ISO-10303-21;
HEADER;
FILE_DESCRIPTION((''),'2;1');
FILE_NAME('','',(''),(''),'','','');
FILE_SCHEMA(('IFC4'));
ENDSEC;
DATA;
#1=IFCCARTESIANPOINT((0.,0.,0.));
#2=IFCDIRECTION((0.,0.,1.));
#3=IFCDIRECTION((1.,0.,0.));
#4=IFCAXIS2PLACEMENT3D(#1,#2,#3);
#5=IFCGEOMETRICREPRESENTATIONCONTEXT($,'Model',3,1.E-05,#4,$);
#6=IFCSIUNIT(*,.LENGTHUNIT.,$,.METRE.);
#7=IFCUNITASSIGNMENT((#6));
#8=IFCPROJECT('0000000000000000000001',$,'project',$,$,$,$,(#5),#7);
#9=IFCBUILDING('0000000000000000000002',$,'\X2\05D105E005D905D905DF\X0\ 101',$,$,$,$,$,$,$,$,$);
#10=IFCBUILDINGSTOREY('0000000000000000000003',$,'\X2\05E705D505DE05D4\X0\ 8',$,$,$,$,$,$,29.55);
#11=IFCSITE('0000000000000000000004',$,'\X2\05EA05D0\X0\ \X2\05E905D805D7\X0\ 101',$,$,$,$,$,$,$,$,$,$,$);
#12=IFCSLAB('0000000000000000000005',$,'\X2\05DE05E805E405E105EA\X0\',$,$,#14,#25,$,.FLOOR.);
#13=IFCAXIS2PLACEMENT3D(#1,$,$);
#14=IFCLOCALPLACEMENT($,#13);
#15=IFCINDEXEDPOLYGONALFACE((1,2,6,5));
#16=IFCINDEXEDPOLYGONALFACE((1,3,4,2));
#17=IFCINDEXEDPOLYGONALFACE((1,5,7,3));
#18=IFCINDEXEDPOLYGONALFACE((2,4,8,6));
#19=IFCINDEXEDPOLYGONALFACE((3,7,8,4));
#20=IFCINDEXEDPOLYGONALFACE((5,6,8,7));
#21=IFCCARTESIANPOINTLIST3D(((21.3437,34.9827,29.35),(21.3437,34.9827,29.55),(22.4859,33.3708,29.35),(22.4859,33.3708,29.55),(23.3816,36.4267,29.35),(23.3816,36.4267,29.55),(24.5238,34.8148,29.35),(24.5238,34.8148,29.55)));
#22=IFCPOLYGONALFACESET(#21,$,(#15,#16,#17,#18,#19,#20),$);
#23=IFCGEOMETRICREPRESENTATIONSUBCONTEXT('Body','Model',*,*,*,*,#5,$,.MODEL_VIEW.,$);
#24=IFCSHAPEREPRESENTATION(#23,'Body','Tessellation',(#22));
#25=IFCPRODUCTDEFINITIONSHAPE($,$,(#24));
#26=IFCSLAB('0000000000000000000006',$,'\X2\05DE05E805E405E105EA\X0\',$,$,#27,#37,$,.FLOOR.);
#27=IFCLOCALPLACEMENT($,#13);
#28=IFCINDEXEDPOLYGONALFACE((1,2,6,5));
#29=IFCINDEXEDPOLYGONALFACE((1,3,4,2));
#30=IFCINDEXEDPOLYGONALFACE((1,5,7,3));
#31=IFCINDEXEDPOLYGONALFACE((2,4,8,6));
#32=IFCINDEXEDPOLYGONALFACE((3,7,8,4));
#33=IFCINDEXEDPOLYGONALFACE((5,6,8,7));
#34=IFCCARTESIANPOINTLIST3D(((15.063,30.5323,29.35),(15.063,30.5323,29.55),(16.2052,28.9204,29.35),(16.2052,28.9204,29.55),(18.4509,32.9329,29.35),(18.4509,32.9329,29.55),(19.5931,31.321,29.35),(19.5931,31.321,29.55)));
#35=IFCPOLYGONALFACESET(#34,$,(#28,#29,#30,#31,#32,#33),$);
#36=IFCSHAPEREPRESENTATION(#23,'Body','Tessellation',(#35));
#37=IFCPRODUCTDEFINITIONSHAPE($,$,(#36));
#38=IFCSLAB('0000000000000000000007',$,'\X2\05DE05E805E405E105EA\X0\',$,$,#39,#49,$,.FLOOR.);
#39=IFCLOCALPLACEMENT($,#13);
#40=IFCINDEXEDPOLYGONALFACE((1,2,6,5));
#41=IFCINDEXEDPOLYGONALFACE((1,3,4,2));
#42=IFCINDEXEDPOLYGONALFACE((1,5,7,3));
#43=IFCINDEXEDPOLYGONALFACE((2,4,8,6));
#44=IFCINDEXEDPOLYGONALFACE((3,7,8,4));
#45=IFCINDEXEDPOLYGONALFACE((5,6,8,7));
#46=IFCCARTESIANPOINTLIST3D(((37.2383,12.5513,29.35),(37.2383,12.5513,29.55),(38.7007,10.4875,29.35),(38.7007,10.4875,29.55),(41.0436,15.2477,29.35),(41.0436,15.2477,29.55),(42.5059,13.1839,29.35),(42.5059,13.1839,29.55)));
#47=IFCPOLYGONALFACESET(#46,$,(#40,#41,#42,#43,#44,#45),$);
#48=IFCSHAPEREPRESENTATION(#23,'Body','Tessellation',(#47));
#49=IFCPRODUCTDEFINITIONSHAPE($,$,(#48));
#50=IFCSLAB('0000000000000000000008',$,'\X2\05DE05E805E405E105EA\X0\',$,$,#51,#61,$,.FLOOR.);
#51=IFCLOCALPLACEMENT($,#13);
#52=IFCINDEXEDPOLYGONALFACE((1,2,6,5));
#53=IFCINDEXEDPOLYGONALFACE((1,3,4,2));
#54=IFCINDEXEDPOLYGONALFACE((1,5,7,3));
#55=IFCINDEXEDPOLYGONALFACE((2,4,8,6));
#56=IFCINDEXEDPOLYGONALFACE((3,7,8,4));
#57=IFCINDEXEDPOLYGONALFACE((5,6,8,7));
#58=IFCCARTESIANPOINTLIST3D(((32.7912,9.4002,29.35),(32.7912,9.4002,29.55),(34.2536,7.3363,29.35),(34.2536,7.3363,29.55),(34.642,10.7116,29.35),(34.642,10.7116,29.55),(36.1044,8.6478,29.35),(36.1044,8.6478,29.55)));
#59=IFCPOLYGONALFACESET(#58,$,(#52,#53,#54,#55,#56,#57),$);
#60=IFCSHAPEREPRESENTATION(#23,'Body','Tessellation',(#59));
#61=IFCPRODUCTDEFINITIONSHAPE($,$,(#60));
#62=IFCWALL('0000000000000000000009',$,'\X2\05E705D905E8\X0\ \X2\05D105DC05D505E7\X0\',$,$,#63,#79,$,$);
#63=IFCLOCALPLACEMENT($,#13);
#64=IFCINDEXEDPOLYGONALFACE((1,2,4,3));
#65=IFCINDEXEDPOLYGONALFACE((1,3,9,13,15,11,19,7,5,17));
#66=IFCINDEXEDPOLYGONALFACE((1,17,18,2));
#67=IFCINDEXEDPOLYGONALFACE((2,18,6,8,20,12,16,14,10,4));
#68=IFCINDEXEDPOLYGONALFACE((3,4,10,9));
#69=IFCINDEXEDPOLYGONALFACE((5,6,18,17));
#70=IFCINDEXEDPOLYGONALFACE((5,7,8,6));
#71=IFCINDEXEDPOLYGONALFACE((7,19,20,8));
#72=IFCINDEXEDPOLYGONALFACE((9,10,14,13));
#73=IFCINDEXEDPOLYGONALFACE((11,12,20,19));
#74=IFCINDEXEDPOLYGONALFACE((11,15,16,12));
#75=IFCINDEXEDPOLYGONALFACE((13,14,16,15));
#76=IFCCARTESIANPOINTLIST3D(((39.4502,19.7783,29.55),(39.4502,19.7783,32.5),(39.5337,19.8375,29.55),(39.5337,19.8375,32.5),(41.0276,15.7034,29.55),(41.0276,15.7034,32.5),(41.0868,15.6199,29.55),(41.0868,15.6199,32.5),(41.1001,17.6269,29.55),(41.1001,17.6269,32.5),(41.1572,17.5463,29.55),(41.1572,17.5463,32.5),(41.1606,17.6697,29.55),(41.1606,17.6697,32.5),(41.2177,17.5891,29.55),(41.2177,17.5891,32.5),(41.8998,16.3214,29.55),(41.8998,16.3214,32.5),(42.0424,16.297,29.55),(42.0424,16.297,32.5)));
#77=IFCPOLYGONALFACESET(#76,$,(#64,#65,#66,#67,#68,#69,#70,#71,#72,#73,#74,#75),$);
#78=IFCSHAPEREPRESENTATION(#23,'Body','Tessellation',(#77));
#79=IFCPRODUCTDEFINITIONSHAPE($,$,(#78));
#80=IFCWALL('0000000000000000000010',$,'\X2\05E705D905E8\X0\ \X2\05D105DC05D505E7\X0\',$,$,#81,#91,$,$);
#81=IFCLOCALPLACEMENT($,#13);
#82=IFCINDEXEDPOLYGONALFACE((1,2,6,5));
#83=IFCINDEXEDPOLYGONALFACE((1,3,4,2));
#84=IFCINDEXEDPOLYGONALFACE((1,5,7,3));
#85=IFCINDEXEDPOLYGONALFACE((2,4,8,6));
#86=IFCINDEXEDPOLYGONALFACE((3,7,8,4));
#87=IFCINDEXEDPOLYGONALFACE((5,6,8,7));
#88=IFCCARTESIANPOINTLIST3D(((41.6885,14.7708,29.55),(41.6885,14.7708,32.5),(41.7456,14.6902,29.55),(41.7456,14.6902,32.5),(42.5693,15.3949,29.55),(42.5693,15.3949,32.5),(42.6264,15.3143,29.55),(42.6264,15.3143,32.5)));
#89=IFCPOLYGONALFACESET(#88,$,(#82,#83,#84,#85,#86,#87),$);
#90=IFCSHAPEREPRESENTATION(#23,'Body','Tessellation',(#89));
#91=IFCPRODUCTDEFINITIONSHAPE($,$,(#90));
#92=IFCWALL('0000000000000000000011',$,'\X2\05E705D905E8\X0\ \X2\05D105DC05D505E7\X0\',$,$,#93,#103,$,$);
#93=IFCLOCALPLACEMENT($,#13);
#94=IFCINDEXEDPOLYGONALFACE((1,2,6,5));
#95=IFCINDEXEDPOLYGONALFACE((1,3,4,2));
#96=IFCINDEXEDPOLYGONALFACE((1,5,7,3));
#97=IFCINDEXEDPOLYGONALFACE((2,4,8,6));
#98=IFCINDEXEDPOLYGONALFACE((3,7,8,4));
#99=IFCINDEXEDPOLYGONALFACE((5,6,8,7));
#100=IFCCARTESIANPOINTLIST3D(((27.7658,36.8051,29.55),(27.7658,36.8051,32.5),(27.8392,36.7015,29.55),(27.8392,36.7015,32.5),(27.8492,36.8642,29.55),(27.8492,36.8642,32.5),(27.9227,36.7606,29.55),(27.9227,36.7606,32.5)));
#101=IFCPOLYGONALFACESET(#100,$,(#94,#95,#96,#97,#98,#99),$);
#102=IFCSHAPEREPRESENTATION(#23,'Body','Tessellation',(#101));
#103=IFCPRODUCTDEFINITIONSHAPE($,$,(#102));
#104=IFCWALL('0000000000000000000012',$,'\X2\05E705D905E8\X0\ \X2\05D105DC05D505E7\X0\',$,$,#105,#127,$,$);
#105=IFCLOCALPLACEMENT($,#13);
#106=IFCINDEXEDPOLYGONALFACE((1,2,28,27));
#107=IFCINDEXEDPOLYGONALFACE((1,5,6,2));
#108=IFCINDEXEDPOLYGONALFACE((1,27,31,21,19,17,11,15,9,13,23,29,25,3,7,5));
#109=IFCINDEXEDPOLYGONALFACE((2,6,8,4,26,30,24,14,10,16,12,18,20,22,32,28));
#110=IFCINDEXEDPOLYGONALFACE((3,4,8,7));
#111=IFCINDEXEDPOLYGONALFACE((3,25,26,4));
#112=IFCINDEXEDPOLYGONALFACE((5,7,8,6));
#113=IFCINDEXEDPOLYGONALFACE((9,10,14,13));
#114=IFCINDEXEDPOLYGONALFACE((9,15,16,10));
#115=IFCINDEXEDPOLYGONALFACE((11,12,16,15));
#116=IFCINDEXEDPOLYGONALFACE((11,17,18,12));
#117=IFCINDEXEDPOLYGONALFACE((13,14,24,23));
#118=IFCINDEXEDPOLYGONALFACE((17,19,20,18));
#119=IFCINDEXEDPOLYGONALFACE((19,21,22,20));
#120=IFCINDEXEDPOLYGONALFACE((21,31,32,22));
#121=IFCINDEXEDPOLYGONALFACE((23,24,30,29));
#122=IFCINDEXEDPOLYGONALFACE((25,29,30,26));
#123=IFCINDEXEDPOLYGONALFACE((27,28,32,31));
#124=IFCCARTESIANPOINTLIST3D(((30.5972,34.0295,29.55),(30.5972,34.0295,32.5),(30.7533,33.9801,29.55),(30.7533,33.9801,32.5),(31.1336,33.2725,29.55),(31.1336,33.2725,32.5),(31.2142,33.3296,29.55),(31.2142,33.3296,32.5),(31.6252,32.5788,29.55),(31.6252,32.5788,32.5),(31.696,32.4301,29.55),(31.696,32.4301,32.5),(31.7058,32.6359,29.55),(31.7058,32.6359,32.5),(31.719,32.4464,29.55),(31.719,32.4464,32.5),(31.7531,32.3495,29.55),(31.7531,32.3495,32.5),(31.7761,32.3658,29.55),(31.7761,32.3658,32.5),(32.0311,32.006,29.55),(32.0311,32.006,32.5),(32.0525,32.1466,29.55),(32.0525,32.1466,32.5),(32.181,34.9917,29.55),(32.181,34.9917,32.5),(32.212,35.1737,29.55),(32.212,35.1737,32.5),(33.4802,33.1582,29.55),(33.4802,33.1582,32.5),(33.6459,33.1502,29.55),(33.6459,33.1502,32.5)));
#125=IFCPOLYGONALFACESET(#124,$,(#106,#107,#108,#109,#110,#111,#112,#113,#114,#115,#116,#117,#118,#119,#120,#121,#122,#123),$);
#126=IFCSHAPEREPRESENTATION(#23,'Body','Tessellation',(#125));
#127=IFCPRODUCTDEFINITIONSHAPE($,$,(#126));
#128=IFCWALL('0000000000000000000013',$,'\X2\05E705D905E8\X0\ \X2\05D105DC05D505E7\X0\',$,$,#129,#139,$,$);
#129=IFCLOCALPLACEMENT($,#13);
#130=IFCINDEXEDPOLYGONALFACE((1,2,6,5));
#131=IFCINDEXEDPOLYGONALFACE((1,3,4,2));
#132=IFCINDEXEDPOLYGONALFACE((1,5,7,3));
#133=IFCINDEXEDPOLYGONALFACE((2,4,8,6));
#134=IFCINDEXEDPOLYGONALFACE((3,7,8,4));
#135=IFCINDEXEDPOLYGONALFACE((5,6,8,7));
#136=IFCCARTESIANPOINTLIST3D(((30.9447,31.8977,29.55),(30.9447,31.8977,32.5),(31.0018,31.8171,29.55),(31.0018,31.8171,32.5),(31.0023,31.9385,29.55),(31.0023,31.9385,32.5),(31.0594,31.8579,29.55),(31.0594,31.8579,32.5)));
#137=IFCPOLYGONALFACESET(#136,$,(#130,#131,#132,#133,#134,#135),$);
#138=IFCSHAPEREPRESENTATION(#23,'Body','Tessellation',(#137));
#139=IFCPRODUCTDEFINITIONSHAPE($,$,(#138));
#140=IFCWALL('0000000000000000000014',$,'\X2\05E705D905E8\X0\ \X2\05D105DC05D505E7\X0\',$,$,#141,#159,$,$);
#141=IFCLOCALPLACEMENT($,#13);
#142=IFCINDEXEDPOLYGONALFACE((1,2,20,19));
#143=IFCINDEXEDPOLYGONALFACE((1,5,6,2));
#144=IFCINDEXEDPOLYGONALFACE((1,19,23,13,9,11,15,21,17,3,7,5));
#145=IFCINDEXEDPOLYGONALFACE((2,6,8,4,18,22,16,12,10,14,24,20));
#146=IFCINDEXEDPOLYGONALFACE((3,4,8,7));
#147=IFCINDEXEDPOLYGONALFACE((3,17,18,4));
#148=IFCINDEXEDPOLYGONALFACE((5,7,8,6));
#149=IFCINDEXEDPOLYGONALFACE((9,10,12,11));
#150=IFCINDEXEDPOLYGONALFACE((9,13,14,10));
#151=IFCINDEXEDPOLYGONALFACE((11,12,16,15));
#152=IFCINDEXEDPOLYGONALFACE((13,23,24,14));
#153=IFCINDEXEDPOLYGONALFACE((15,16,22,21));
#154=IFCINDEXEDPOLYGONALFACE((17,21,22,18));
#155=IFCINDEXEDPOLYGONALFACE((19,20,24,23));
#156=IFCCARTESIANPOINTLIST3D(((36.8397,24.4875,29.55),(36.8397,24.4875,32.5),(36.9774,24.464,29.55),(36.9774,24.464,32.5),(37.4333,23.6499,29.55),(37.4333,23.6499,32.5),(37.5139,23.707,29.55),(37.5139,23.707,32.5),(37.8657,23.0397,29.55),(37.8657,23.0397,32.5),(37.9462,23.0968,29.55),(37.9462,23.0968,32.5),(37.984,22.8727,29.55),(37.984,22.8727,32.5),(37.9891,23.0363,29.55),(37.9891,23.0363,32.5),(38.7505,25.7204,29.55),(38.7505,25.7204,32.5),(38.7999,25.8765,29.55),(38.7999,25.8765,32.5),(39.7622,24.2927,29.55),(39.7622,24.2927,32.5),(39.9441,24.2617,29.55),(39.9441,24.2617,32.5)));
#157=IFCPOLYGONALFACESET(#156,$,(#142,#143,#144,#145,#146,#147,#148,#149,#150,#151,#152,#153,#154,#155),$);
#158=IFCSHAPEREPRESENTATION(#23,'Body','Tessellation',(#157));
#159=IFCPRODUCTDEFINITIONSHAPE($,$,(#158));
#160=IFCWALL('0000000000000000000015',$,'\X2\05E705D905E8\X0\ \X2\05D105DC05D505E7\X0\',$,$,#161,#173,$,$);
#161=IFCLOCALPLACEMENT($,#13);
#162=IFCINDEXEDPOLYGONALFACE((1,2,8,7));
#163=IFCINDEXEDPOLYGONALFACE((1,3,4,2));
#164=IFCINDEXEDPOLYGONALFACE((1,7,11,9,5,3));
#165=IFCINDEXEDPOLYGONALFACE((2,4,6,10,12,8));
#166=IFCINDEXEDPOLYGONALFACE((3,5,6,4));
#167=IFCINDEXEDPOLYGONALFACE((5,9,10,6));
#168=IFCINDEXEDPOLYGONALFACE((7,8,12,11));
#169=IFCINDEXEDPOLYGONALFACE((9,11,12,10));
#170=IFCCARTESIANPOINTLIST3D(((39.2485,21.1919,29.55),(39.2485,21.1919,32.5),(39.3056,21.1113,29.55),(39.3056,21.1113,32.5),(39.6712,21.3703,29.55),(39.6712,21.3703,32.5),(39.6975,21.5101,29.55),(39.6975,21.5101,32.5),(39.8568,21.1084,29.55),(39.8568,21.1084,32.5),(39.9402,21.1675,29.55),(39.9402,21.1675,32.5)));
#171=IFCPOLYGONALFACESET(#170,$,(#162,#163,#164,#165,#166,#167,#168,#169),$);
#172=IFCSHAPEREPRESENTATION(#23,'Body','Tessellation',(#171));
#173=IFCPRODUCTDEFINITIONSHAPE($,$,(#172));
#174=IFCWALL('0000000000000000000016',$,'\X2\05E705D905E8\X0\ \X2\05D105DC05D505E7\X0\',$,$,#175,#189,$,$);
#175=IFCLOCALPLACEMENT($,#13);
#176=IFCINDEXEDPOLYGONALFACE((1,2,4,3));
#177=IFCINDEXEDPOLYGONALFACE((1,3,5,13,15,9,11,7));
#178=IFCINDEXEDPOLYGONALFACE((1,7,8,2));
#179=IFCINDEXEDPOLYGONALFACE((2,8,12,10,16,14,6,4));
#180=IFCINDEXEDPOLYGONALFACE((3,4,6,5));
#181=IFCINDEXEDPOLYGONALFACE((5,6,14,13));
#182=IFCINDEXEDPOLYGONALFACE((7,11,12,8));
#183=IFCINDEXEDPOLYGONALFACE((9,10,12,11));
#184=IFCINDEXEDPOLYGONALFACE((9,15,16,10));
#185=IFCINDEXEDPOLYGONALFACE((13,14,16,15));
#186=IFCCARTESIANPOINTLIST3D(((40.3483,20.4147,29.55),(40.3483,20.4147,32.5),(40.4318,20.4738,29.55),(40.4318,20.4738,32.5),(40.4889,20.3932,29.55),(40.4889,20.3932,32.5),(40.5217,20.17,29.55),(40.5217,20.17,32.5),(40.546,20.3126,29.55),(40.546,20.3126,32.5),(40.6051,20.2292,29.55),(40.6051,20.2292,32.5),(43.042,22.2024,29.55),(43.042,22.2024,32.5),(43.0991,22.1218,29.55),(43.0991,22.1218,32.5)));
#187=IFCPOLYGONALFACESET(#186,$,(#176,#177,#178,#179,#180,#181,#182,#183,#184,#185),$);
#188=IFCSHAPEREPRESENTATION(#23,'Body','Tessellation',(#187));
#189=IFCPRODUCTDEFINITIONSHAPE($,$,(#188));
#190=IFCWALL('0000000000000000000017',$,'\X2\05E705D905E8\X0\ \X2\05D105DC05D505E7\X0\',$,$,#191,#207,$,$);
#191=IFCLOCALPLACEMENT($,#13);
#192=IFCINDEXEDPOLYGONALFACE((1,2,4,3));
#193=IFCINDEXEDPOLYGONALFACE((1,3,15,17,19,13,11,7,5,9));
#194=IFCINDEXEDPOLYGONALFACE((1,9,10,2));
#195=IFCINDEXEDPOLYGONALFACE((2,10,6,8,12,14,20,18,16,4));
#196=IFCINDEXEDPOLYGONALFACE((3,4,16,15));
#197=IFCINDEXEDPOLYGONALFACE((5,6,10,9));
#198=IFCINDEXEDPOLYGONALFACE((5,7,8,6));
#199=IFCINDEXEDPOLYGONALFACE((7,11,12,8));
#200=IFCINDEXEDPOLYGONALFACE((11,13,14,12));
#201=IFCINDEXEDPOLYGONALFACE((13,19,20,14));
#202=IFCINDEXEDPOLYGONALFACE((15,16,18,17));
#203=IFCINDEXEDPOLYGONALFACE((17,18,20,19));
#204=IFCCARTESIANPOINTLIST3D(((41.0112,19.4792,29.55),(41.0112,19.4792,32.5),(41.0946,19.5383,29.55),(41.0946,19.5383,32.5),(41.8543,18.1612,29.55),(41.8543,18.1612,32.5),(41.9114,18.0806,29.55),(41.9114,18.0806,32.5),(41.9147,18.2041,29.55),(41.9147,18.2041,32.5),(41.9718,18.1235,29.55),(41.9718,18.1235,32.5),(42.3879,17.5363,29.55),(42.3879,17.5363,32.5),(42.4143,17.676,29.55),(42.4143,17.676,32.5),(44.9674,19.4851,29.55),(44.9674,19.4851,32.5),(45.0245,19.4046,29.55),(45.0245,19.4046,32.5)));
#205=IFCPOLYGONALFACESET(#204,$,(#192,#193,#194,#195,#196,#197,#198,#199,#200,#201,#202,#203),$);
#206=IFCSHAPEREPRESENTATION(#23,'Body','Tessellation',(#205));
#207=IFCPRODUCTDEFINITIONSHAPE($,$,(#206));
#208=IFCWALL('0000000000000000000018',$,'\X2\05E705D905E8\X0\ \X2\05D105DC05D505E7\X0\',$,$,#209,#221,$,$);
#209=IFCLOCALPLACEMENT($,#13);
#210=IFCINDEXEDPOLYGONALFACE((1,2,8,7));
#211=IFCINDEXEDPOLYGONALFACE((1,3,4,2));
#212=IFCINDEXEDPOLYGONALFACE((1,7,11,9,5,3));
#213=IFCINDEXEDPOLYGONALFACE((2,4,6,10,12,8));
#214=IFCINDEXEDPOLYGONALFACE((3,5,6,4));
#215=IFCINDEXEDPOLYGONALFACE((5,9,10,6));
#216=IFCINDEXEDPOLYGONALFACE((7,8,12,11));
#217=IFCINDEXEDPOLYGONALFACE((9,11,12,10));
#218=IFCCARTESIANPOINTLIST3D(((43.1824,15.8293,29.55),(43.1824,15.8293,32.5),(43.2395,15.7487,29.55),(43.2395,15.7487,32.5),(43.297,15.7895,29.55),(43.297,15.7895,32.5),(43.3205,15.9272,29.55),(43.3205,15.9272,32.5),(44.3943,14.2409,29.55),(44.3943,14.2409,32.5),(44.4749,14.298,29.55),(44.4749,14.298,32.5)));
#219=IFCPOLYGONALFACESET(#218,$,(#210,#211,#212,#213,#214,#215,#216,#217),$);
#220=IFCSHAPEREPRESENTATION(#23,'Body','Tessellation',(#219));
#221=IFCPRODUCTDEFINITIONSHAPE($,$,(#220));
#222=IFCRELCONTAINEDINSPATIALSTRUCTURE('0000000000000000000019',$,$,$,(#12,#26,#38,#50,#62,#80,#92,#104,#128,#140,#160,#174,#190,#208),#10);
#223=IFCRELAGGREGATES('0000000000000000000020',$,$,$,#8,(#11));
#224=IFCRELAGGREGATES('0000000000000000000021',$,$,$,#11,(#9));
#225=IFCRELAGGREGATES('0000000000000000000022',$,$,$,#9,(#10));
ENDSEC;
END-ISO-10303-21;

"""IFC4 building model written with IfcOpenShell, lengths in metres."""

from ifc_helpers import new_model, si_unit, frame, origin_with_axes, context, subcontext, project, spatial, polyline, outline, extrude, element, save


model = new_model("IFC4")

# Units and contexts
model_context = context("Model", 3, precision=1e-05, world=origin_with_axes())
body_context = subcontext(model_context, "Body", "Model", "MODEL_VIEW")
ifc_project = project(units=[si_unit("LENGTHUNIT", "METRE")], contexts=[model_context])

# Site, building, storey
site = spatial("IfcSite", under=ifc_project, Name="תא שטח 101")
building = spatial("IfcBuilding", under=site, Name="בניין 101")
storey = spatial("IfcBuildingStorey", under=building, Name="קומה 8", Elevation=29.55)

# Slabs
element("IfcSlab", 1, inside=storey, Name="מרפסת", PredefinedType="FLOOR", context=body_context, shape_type="SweptSolid", body=[
    extrude(outline(polyline([(21.3437, 34.9827), (23.3816, 36.4267), (24.5238, 34.8148), (22.4859, 33.3708), (21.3437, 34.9827)])), frame((0.0, 0.0, 29.35)), (0.0, 0.0, 1.0), 0.2),
])
element("IfcSlab", 2, inside=storey, Name="מרפסת", PredefinedType="FLOOR", context=body_context, shape_type="SweptSolid", body=[
    extrude(outline(polyline([(15.063, 30.5323), (18.4509, 32.9329), (19.5931, 31.321), (16.2052, 28.9204), (15.063, 30.5323)])), frame((0.0, 0.0, 29.35)), (0.0, 0.0, 1.0), 0.2),
])
element("IfcSlab", 3, inside=storey, Name="מרפסת", PredefinedType="FLOOR", context=body_context, shape_type="SweptSolid", body=[
    extrude(outline(polyline([(37.2383, 12.5513), (41.0436, 15.2477), (42.5059, 13.1839), (38.7007, 10.4875), (37.2383, 12.5513)])), frame((0.0, 0.0, 29.35)), (0.0, 0.0, 1.0), 0.2),
])
element("IfcSlab", 4, inside=storey, Name="מרפסת", PredefinedType="FLOOR", context=body_context, shape_type="SweptSolid", body=[
    extrude(outline(polyline([(32.7912, 9.4002), (34.642, 10.7116), (36.1044, 8.6478), (34.2536, 7.3363), (32.7912, 9.4002)])), frame((0.0, 0.0, 29.35)), (0.0, 0.0, 1.0), 0.2),
])

# Walls
element("IfcWall", 5, inside=storey, Name="קיר בלוק", context=body_context, shape_type="SweptSolid", body=[
    extrude(outline(polyline([(41.0868, 15.6199), (42.0424, 16.297), (41.1572, 17.5463), (41.2177, 17.5891), (41.1606, 17.6697), (41.1001, 17.6269), (39.5337, 19.8375), (39.4502, 19.7783), (41.8998, 16.3214), (41.0276, 15.7034), (41.0868, 15.6199)])), frame((0.0, 0.0, 29.55)), (0.0, 0.0, 1.0), 2.95),
])
element("IfcWall", 6, inside=storey, Name="קיר בלוק", context=body_context, shape_type="SweptSolid", body=[
    extrude(outline(polyline([(42.5693, 15.3949), (41.6885, 14.7708), (41.7456, 14.6902), (42.6264, 15.3143), (42.5693, 15.3949)])), frame((0.0, 0.0, 29.55)), (0.0, 0.0, 1.0), 2.95),
])
element("IfcWall", 7, inside=storey, Name="קיר בלוק", context=body_context, shape_type="SweptSolid", body=[
    extrude(outline(polyline([(27.9227, 36.7606), (27.8492, 36.8642), (27.7658, 36.8051), (27.8392, 36.7015), (27.9227, 36.7606)])), frame((0.0, 0.0, 29.55)), (0.0, 0.0, 1.0), 2.95),
])
element("IfcWall", 8, inside=storey, Name="קיר בלוק", context=body_context, shape_type="SweptSolid", body=[
    extrude(outline(polyline([(32.181, 34.9917), (33.4802, 33.1582), (32.0525, 32.1466), (31.7058, 32.6359), (31.6252, 32.5788), (31.719, 32.4464), (31.696, 32.4301), (31.7531, 32.3495), (31.7761, 32.3658), (32.0311, 32.006), (33.6459, 33.1502), (32.212, 35.1737), (30.5972, 34.0295), (31.1336, 33.2725), (31.2142, 33.3296), (30.7533, 33.9801), (32.181, 34.9917)])), frame((0.0, 0.0, 29.55)), (0.0, 0.0, 1.0), 2.95),
])
element("IfcWall", 9, inside=storey, Name="קיר בלוק", context=body_context, shape_type="SweptSolid", body=[
    extrude(outline(polyline([(31.0023, 31.9385), (30.9447, 31.8977), (31.0018, 31.8171), (31.0594, 31.8579), (31.0023, 31.9385)])), frame((0.0, 0.0, 29.55)), (0.0, 0.0, 1.0), 2.95),
])
element("IfcWall", 10, inside=storey, Name="קיר בלוק", context=body_context, shape_type="SweptSolid", body=[
    extrude(outline(polyline([(37.5139, 23.707), (36.9774, 24.464), (38.7505, 25.7204), (39.7622, 24.2927), (37.9891, 23.0363), (37.9462, 23.0968), (37.8657, 23.0397), (37.984, 22.8727), (39.9441, 24.2617), (38.7999, 25.8765), (36.8397, 24.4875), (37.4333, 23.6499), (37.5139, 23.707)])), frame((0.0, 0.0, 29.55)), (0.0, 0.0, 1.0), 2.95),
])
element("IfcWall", 11, inside=storey, Name="קיר בלוק", context=body_context, shape_type="SweptSolid", body=[
    extrude(outline(polyline([(39.9402, 21.1675), (39.6975, 21.5101), (39.2485, 21.1919), (39.3056, 21.1113), (39.6712, 21.3703), (39.8568, 21.1084), (39.9402, 21.1675)])), frame((0.0, 0.0, 29.55)), (0.0, 0.0, 1.0), 2.95),
])
element("IfcWall", 12, inside=storey, Name="קיר בלוק", context=body_context, shape_type="SweptSolid", body=[
    extrude(outline(polyline([(40.546, 20.3126), (43.0991, 22.1218), (43.042, 22.2024), (40.4889, 20.3932), (40.4318, 20.4738), (40.3483, 20.4147), (40.5217, 20.17), (40.6051, 20.2292), (40.546, 20.3126)])), frame((0.0, 0.0, 29.55)), (0.0, 0.0, 1.0), 2.95),
])
element("IfcWall", 13, inside=storey, Name="קיר בלוק", context=body_context, shape_type="SweptSolid", body=[
    extrude(outline(polyline([(41.9718, 18.1235), (42.3879, 17.5363), (45.0245, 19.4046), (44.9674, 19.4851), (42.4143, 17.676), (41.0946, 19.5383), (41.0112, 19.4792), (41.9147, 18.2041), (41.8543, 18.1612), (41.9114, 18.0806), (41.9718, 18.1235)])), frame((0.0, 0.0, 29.55)), (0.0, 0.0, 1.0), 2.95),
])
element("IfcWall", 14, inside=storey, Name="קיר בלוק", context=body_context, shape_type="SweptSolid", body=[
    extrude(outline(polyline([(43.3205, 15.9272), (43.1824, 15.8293), (43.2395, 15.7487), (43.297, 15.7895), (44.3943, 14.2409), (44.4749, 14.298), (43.3205, 15.9272)])), frame((0.0, 0.0, 29.55)), (0.0, 0.0, 1.0), 2.95),
])

save(model, "model.ifc")
